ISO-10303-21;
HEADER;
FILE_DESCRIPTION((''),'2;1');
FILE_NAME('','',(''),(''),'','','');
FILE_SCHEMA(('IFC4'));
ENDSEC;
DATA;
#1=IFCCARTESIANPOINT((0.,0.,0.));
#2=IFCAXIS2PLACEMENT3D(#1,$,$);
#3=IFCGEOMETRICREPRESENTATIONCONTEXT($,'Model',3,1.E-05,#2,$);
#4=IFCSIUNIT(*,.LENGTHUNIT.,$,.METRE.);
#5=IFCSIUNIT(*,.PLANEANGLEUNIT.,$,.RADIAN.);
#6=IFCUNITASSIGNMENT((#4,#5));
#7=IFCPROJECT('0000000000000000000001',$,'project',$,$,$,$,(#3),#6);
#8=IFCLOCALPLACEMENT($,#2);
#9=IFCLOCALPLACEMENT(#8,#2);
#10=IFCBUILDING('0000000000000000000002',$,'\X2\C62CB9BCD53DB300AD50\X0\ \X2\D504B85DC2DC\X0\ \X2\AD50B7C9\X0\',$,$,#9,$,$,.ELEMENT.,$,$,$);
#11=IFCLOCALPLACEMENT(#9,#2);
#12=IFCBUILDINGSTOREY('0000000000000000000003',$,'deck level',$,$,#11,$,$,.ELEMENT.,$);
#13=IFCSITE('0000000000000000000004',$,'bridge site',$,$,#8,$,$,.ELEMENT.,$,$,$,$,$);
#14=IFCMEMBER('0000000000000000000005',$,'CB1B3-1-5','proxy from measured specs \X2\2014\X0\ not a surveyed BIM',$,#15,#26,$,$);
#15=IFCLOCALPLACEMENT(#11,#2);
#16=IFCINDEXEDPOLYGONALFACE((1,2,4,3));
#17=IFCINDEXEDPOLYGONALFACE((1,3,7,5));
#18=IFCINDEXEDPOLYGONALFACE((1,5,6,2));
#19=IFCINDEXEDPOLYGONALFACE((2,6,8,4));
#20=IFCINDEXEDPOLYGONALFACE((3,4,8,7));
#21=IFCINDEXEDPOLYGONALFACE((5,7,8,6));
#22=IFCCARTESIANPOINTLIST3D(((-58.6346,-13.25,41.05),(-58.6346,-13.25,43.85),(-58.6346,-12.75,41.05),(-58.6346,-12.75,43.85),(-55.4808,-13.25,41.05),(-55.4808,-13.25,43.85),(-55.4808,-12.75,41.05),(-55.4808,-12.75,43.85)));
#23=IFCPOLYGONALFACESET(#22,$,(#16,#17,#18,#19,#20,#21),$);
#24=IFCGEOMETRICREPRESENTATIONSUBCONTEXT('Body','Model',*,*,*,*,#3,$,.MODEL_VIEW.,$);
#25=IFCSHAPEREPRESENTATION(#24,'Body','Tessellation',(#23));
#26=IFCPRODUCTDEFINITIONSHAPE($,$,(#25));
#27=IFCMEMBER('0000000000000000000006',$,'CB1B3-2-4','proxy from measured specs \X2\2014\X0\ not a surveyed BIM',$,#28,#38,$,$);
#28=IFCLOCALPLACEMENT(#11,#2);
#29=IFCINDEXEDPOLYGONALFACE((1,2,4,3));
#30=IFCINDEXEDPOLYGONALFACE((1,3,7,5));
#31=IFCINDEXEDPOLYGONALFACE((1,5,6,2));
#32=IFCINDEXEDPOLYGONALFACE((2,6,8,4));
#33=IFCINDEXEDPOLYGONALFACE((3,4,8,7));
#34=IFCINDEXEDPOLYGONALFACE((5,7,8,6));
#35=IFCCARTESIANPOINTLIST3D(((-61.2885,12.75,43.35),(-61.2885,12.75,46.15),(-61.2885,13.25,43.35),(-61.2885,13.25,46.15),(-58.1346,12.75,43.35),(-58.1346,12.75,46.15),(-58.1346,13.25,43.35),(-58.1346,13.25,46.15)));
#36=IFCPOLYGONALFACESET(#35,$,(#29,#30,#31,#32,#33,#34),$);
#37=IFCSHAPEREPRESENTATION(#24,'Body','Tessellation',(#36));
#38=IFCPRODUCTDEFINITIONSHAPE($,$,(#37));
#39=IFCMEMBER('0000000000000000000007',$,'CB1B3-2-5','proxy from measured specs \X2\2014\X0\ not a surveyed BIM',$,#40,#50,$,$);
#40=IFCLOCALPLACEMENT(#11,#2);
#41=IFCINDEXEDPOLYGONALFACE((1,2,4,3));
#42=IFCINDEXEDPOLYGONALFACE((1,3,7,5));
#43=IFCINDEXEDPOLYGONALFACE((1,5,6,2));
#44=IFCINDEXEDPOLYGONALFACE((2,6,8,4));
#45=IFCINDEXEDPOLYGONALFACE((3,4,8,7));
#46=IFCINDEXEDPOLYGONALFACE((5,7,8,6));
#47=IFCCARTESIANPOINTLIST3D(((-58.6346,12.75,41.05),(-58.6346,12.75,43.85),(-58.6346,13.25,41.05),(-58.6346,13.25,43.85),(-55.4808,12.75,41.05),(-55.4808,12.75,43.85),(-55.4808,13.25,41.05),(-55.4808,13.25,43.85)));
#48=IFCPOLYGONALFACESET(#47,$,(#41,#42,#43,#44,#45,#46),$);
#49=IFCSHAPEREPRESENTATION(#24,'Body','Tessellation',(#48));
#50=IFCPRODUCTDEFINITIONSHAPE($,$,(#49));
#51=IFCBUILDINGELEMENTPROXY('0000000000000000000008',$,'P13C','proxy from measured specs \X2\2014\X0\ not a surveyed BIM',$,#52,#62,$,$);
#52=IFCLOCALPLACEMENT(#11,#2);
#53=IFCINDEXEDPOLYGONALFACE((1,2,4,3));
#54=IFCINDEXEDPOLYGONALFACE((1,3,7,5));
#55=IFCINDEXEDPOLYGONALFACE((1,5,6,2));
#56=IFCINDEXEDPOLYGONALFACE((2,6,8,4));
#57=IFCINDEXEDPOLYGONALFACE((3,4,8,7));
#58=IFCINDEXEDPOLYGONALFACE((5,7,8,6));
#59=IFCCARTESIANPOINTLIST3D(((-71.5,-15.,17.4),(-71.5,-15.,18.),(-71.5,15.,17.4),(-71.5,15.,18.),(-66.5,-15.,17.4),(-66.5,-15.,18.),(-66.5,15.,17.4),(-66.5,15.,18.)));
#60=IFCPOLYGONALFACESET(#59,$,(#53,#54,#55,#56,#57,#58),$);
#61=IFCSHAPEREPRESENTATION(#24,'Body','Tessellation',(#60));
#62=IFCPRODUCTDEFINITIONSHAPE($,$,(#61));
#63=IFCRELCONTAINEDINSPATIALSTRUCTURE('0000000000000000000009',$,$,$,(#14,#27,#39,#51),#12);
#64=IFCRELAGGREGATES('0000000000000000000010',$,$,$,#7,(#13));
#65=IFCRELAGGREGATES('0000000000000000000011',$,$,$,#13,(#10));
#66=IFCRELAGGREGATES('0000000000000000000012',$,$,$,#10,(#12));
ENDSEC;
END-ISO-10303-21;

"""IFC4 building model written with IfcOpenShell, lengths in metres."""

from ifc_helpers import new_model, si_unit, frame, origin, origin_2d, place, context, subcontext, project, spatial, rectangle, extrude, element, save


model = new_model("IFC4")

# Units and contexts
model_context = context("Model", 3, precision=1e-05, world=origin())
body_context = subcontext(model_context, "Body", "Model", "MODEL_VIEW")
ifc_project = project(units=[si_unit("LENGTHUNIT", "METRE"), si_unit("PLANEANGLEUNIT", "RADIAN")], contexts=[model_context])

# Site, building, storey
site_placement = place(None, origin())
site = spatial("IfcSite", under=ifc_project, at=site_placement, Name="bridge site", CompositionType="ELEMENT")
building_placement = place(site_placement, origin())
building = spatial("IfcBuilding", under=site, at=building_placement, Name="올림픽대교 프록시 교량", CompositionType="ELEMENT")
storey_placement = place(building_placement, origin())
storey = spatial("IfcBuildingStorey", under=building, at=storey_placement, Name="deck level", CompositionType="ELEMENT")

# Members
member_1_placement = place(storey_placement, frame((-57.0577, -13.0, 41.05)))
element("IfcMember", 1, at=member_1_placement, inside=storey, Name="CB1B3-1-5", Description="proxy from measured specs — not a surveyed BIM", context=body_context, shape_type="SweptSolid", body=[
    extrude(rectangle(XDim=3.1538, YDim=0.5, at=origin_2d()), origin(), (0.0, 0.0, 1.0), 2.8),
])
member_2_placement = place(storey_placement, frame((-59.7115, 13.0, 43.35)))
element("IfcMember", 2, at=member_2_placement, inside=storey, Name="CB1B3-2-4", Description="proxy from measured specs — not a surveyed BIM", context=body_context, shape_type="SweptSolid", body=[
    extrude(rectangle(XDim=3.1538, YDim=0.5, at=origin_2d()), origin(), (0.0, 0.0, 1.0), 2.8),
])
member_3_placement = place(storey_placement, frame((-57.0577, 13.0, 41.05)))
element("IfcMember", 3, at=member_3_placement, inside=storey, Name="CB1B3-2-5", Description="proxy from measured specs — not a surveyed BIM", context=body_context, shape_type="SweptSolid", body=[
    extrude(rectangle(XDim=3.1538, YDim=0.5, at=origin_2d()), origin(), (0.0, 0.0, 1.0), 2.8),
])

# Building element proxy
proxy_placement = place(storey_placement, frame((-69.0, 0.0, 17.4)))
element("IfcBuildingElementProxy", 4, at=proxy_placement, inside=storey, Name="P13C", Description="proxy from measured specs — not a surveyed BIM", context=body_context, shape_type="SweptSolid", body=[
    extrude(rectangle(XDim=5.0, YDim=30.0, at=origin_2d()), origin(), (0.0, 0.0, 1.0), 0.6),
])

save(model, "model.ifc")
